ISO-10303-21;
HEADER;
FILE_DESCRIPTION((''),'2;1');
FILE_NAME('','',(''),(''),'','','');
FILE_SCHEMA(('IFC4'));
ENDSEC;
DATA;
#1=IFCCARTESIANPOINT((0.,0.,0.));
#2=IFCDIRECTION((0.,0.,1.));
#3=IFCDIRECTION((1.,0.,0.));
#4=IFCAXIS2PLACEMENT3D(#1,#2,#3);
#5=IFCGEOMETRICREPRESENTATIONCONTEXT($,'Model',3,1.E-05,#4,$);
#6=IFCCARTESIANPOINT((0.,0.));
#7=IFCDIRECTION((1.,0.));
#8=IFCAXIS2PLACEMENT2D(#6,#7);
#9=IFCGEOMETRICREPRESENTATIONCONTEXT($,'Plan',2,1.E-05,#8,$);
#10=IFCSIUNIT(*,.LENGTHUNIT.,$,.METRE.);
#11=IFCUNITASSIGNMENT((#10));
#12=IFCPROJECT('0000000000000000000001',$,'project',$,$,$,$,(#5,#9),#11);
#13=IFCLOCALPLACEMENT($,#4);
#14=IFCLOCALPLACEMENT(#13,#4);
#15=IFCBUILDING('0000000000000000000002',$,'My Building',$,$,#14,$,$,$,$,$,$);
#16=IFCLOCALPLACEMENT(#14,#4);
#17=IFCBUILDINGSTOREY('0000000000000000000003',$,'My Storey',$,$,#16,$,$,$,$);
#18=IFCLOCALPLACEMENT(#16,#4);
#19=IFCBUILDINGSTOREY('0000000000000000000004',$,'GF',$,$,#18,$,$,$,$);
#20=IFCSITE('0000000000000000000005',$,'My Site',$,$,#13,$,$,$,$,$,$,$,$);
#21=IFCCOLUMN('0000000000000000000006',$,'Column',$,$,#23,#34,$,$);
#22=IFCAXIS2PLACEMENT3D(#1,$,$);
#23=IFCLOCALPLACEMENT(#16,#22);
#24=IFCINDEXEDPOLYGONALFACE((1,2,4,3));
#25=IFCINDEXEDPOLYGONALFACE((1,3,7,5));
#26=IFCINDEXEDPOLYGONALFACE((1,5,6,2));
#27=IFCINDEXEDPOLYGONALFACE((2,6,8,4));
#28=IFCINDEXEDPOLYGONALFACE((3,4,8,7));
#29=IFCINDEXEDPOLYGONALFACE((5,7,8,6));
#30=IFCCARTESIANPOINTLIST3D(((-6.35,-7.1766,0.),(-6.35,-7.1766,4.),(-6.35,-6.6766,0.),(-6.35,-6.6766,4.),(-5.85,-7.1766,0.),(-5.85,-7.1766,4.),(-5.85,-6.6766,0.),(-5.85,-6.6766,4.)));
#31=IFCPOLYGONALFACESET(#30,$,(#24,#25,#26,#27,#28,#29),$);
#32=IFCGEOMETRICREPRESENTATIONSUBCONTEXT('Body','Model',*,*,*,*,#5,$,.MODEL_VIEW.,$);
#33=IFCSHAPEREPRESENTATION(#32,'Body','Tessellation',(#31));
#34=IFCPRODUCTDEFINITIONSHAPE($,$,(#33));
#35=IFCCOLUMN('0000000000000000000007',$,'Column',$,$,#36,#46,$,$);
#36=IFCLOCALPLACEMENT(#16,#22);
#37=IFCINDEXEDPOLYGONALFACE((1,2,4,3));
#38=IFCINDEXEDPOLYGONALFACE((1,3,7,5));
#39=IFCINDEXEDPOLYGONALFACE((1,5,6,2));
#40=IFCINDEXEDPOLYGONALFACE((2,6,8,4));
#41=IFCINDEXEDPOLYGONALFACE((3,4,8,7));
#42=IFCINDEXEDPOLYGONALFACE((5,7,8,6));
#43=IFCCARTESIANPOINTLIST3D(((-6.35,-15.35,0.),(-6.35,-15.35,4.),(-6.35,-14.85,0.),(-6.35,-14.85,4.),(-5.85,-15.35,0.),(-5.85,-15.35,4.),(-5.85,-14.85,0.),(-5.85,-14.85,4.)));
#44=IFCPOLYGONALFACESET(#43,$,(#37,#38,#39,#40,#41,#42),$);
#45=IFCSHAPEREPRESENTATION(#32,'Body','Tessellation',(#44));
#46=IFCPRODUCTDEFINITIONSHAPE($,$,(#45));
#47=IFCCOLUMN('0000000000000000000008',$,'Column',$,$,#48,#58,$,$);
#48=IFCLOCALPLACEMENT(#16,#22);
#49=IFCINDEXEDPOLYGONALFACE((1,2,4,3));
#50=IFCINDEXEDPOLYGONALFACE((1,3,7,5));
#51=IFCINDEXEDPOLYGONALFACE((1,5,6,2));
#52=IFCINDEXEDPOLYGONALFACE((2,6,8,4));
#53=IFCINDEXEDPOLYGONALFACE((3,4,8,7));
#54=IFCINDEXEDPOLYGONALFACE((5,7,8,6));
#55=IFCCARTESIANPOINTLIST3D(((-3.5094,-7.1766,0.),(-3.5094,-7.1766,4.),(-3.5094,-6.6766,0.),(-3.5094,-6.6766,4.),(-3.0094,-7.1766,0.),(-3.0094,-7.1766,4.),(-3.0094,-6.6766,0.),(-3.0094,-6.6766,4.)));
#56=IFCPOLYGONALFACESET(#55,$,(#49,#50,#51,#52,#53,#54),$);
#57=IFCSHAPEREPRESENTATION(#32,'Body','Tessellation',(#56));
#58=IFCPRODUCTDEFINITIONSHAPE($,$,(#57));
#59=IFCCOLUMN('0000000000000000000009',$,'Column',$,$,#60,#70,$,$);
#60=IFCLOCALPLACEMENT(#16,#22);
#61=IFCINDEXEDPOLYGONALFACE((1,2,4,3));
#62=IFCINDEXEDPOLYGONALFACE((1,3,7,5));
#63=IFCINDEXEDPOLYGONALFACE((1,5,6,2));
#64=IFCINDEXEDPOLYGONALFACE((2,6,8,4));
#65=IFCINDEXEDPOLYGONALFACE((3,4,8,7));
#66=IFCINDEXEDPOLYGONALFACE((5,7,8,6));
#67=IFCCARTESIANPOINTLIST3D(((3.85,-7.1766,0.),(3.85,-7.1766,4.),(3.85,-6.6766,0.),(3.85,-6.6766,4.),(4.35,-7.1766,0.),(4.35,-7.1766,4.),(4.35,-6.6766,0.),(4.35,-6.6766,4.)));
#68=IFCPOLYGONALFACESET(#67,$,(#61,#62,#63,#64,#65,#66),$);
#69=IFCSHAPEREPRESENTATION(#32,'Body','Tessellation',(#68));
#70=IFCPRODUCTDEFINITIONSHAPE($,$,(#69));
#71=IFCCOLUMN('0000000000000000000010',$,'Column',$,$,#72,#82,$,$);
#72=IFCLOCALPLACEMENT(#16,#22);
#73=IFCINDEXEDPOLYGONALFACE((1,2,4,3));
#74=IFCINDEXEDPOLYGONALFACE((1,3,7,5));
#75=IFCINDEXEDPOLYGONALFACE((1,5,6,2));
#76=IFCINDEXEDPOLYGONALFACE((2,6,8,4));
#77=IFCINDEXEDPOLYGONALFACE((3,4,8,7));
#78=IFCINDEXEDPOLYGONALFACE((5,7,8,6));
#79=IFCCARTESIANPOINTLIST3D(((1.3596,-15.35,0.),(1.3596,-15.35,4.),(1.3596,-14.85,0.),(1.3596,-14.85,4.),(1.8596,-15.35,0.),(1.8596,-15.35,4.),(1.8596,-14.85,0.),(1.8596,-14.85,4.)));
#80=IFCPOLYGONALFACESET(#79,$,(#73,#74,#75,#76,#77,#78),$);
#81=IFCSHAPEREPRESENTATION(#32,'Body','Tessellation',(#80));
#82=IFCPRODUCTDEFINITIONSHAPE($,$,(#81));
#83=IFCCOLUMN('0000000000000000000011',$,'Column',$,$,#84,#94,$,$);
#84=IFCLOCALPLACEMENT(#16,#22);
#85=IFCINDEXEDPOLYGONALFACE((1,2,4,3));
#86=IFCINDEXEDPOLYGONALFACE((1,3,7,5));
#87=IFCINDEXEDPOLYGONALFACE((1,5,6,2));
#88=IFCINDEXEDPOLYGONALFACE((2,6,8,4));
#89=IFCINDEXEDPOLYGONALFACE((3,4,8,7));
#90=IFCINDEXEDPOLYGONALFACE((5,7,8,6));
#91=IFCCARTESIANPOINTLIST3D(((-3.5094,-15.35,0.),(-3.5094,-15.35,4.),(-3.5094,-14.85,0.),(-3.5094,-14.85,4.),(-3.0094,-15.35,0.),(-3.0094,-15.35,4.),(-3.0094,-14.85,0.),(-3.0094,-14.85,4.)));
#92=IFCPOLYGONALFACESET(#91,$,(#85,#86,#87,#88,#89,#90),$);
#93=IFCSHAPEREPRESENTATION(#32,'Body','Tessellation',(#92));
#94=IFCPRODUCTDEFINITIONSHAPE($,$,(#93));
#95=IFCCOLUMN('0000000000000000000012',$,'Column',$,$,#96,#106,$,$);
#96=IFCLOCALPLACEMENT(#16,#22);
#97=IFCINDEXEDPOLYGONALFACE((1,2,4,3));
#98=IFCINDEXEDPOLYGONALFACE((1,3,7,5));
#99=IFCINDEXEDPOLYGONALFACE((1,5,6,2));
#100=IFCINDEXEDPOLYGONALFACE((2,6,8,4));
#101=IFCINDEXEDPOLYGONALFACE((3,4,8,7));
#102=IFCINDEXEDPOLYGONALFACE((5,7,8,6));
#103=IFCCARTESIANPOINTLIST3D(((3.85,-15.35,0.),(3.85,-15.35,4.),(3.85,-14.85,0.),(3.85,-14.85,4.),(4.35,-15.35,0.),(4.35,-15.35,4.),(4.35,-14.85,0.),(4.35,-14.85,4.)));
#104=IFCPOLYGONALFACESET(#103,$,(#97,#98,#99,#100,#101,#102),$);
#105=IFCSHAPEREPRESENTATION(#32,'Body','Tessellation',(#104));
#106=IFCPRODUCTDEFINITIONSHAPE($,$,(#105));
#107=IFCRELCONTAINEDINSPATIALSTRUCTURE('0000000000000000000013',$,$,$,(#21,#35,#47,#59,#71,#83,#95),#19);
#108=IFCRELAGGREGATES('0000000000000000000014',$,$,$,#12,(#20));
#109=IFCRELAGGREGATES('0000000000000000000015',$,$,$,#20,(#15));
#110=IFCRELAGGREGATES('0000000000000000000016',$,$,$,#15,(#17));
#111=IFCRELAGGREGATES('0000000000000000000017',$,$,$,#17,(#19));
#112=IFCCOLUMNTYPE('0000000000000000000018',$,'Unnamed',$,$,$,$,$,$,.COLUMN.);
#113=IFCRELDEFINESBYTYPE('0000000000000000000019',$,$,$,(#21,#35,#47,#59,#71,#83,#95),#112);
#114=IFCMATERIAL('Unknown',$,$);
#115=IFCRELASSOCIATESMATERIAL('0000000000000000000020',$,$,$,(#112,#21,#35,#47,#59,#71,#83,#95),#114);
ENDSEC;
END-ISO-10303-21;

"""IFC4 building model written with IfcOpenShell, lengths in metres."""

from ifc_helpers import new_model, si_unit, frame, origin_with_axes, origin_2d_with_axis, place, context, subcontext, project, spatial, rectangle, extrude, material, material_profile, profile_set, profile_usage, type_object, element, save


model = new_model("IFC4")

# Units and contexts
model_context = context("Model", 3, precision=1e-05, world=origin_with_axes())
plan_context = context("Plan", 2, precision=1e-05, world=origin_2d_with_axis())
body_context_1 = subcontext(model_context, "Body", "Model", "MODEL_VIEW")
ifc_project = project(units=[si_unit("LENGTHUNIT", "METRE")], contexts=[model_context, plan_context])

# Site, building, storeys
site_placement = place(None, origin_with_axes())
site = spatial("IfcSite", under=ifc_project, at=site_placement, Name="My Site")
building_placement = place(site_placement, origin_with_axes())
building = spatial("IfcBuilding", under=site, at=building_placement, Name="My Building")
storey_1_placement = place(building_placement, origin_with_axes())
storey_1 = spatial("IfcBuildingStorey", under=building, at=storey_1_placement, Name="My Storey")
storey_2_placement = place(storey_1_placement, origin_with_axes())
storey_2 = spatial("IfcBuildingStorey", under=storey_1, at=storey_2_placement, Name="GF")

# Columns
ifc_material = material(Name="Unknown")
ifc_material_profile = material_profile(ifc_material, rectangle(XDim=0.5, YDim=0.5))
ifc_profile_set = profile_set([ifc_material_profile])
ifc_profile_usage_1 = profile_usage(ifc_profile_set, cardinal=5)
column_type = type_object("IfcColumnType", Name="Unnamed", PredefinedType="COLUMN", material=ifc_profile_set)
column_1_placement = place(storey_2_placement, frame((-6.1, -6.9266, 0.0), z_axis=(0.0, 0.0, 1.0), x_axis=(1.0, 0.0, 0.0)))
element("IfcColumn", 1, at=column_1_placement, inside=storey_2, type_object=column_type, material=ifc_profile_usage_1, Name="Column", context=body_context_1, shape_type="SweptSolid", body=[
    extrude(rectangle(XDim=0.5, YDim=0.5), origin_with_axes(), (0.0, 0.0, 1.0), 4.0),
])
ifc_profile_usage_2 = profile_usage(ifc_profile_set, cardinal=5)
column_2_placement = place(storey_2_placement, frame((-6.1, -15.1, 0.0), z_axis=(0.0, 0.0, 1.0), x_axis=(1.0, 0.0, 0.0)))
element("IfcColumn", 2, at=column_2_placement, inside=storey_2, type_object=column_type, material=ifc_profile_usage_2, Name="Column", context=body_context_1, shape_type="SweptSolid", body=[
    extrude(rectangle(XDim=0.5, YDim=0.5), origin_with_axes(), (0.0, 0.0, 1.0), 4.0),
])
ifc_profile_usage_3 = profile_usage(ifc_profile_set, cardinal=5)
column_3_placement = place(storey_2_placement, frame((-3.2594, -6.9266, 0.0), z_axis=(0.0, 0.0, 1.0), x_axis=(1.0, 0.0, 0.0)))
element("IfcColumn", 3, at=column_3_placement, inside=storey_2, type_object=column_type, material=ifc_profile_usage_3, Name="Column", context=body_context_1, shape_type="SweptSolid", body=[
    extrude(rectangle(XDim=0.5, YDim=0.5), origin_with_axes(), (0.0, 0.0, 1.0), 4.0),
])
ifc_profile_usage_4 = profile_usage(ifc_profile_set, cardinal=5)
column_4_placement = place(storey_2_placement, frame((4.1, -6.9266, 0.0), z_axis=(0.0, 0.0, 1.0), x_axis=(1.0, 0.0, 0.0)))
element("IfcColumn", 4, at=column_4_placement, inside=storey_2, type_object=column_type, material=ifc_profile_usage_4, Name="Column", context=body_context_1, shape_type="SweptSolid", body=[
    extrude(rectangle(XDim=0.5, YDim=0.5), origin_with_axes(), (0.0, 0.0, 1.0), 4.0),
])
ifc_profile_usage_5 = profile_usage(ifc_profile_set, cardinal=5)
column_5_placement = place(storey_2_placement, frame((1.6096, -15.1, 0.0), z_axis=(0.0, 0.0, 1.0), x_axis=(1.0, 0.0, 0.0)))
element("IfcColumn", 5, at=column_5_placement, inside=storey_2, type_object=column_type, material=ifc_profile_usage_5, Name="Column", context=body_context_1, shape_type="SweptSolid", body=[
    extrude(rectangle(XDim=0.5, YDim=0.5), origin_with_axes(), (0.0, 0.0, 1.0), 4.0),
])
ifc_profile_usage_6 = profile_usage(ifc_profile_set, cardinal=5)
column_6_placement = place(storey_2_placement, frame((-3.2594, -15.1, 0.0), z_axis=(0.0, 0.0, 1.0), x_axis=(1.0, 0.0, 0.0)))
element("IfcColumn", 6, at=column_6_placement, inside=storey_2, type_object=column_type, material=ifc_profile_usage_6, Name="Column", context=body_context_1, shape_type="SweptSolid", body=[
    extrude(rectangle(XDim=0.5, YDim=0.5), origin_with_axes(), (0.0, 0.0, 1.0), 4.0),
])
ifc_profile_usage_7 = profile_usage(ifc_profile_set, cardinal=5)
column_7_placement = place(storey_2_placement, frame((4.1, -15.1, 0.0), z_axis=(0.0, 0.0, 1.0), x_axis=(1.0, 0.0, 0.0)))
element("IfcColumn", 7, at=column_7_placement, inside=storey_2, type_object=column_type, material=ifc_profile_usage_7, Name="Column", context=body_context_1, shape_type="SweptSolid", body=[
    extrude(rectangle(XDim=0.5, YDim=0.5), origin_with_axes(), (0.0, 0.0, 1.0), 4.0),
])

save(model, "model.ifc")
